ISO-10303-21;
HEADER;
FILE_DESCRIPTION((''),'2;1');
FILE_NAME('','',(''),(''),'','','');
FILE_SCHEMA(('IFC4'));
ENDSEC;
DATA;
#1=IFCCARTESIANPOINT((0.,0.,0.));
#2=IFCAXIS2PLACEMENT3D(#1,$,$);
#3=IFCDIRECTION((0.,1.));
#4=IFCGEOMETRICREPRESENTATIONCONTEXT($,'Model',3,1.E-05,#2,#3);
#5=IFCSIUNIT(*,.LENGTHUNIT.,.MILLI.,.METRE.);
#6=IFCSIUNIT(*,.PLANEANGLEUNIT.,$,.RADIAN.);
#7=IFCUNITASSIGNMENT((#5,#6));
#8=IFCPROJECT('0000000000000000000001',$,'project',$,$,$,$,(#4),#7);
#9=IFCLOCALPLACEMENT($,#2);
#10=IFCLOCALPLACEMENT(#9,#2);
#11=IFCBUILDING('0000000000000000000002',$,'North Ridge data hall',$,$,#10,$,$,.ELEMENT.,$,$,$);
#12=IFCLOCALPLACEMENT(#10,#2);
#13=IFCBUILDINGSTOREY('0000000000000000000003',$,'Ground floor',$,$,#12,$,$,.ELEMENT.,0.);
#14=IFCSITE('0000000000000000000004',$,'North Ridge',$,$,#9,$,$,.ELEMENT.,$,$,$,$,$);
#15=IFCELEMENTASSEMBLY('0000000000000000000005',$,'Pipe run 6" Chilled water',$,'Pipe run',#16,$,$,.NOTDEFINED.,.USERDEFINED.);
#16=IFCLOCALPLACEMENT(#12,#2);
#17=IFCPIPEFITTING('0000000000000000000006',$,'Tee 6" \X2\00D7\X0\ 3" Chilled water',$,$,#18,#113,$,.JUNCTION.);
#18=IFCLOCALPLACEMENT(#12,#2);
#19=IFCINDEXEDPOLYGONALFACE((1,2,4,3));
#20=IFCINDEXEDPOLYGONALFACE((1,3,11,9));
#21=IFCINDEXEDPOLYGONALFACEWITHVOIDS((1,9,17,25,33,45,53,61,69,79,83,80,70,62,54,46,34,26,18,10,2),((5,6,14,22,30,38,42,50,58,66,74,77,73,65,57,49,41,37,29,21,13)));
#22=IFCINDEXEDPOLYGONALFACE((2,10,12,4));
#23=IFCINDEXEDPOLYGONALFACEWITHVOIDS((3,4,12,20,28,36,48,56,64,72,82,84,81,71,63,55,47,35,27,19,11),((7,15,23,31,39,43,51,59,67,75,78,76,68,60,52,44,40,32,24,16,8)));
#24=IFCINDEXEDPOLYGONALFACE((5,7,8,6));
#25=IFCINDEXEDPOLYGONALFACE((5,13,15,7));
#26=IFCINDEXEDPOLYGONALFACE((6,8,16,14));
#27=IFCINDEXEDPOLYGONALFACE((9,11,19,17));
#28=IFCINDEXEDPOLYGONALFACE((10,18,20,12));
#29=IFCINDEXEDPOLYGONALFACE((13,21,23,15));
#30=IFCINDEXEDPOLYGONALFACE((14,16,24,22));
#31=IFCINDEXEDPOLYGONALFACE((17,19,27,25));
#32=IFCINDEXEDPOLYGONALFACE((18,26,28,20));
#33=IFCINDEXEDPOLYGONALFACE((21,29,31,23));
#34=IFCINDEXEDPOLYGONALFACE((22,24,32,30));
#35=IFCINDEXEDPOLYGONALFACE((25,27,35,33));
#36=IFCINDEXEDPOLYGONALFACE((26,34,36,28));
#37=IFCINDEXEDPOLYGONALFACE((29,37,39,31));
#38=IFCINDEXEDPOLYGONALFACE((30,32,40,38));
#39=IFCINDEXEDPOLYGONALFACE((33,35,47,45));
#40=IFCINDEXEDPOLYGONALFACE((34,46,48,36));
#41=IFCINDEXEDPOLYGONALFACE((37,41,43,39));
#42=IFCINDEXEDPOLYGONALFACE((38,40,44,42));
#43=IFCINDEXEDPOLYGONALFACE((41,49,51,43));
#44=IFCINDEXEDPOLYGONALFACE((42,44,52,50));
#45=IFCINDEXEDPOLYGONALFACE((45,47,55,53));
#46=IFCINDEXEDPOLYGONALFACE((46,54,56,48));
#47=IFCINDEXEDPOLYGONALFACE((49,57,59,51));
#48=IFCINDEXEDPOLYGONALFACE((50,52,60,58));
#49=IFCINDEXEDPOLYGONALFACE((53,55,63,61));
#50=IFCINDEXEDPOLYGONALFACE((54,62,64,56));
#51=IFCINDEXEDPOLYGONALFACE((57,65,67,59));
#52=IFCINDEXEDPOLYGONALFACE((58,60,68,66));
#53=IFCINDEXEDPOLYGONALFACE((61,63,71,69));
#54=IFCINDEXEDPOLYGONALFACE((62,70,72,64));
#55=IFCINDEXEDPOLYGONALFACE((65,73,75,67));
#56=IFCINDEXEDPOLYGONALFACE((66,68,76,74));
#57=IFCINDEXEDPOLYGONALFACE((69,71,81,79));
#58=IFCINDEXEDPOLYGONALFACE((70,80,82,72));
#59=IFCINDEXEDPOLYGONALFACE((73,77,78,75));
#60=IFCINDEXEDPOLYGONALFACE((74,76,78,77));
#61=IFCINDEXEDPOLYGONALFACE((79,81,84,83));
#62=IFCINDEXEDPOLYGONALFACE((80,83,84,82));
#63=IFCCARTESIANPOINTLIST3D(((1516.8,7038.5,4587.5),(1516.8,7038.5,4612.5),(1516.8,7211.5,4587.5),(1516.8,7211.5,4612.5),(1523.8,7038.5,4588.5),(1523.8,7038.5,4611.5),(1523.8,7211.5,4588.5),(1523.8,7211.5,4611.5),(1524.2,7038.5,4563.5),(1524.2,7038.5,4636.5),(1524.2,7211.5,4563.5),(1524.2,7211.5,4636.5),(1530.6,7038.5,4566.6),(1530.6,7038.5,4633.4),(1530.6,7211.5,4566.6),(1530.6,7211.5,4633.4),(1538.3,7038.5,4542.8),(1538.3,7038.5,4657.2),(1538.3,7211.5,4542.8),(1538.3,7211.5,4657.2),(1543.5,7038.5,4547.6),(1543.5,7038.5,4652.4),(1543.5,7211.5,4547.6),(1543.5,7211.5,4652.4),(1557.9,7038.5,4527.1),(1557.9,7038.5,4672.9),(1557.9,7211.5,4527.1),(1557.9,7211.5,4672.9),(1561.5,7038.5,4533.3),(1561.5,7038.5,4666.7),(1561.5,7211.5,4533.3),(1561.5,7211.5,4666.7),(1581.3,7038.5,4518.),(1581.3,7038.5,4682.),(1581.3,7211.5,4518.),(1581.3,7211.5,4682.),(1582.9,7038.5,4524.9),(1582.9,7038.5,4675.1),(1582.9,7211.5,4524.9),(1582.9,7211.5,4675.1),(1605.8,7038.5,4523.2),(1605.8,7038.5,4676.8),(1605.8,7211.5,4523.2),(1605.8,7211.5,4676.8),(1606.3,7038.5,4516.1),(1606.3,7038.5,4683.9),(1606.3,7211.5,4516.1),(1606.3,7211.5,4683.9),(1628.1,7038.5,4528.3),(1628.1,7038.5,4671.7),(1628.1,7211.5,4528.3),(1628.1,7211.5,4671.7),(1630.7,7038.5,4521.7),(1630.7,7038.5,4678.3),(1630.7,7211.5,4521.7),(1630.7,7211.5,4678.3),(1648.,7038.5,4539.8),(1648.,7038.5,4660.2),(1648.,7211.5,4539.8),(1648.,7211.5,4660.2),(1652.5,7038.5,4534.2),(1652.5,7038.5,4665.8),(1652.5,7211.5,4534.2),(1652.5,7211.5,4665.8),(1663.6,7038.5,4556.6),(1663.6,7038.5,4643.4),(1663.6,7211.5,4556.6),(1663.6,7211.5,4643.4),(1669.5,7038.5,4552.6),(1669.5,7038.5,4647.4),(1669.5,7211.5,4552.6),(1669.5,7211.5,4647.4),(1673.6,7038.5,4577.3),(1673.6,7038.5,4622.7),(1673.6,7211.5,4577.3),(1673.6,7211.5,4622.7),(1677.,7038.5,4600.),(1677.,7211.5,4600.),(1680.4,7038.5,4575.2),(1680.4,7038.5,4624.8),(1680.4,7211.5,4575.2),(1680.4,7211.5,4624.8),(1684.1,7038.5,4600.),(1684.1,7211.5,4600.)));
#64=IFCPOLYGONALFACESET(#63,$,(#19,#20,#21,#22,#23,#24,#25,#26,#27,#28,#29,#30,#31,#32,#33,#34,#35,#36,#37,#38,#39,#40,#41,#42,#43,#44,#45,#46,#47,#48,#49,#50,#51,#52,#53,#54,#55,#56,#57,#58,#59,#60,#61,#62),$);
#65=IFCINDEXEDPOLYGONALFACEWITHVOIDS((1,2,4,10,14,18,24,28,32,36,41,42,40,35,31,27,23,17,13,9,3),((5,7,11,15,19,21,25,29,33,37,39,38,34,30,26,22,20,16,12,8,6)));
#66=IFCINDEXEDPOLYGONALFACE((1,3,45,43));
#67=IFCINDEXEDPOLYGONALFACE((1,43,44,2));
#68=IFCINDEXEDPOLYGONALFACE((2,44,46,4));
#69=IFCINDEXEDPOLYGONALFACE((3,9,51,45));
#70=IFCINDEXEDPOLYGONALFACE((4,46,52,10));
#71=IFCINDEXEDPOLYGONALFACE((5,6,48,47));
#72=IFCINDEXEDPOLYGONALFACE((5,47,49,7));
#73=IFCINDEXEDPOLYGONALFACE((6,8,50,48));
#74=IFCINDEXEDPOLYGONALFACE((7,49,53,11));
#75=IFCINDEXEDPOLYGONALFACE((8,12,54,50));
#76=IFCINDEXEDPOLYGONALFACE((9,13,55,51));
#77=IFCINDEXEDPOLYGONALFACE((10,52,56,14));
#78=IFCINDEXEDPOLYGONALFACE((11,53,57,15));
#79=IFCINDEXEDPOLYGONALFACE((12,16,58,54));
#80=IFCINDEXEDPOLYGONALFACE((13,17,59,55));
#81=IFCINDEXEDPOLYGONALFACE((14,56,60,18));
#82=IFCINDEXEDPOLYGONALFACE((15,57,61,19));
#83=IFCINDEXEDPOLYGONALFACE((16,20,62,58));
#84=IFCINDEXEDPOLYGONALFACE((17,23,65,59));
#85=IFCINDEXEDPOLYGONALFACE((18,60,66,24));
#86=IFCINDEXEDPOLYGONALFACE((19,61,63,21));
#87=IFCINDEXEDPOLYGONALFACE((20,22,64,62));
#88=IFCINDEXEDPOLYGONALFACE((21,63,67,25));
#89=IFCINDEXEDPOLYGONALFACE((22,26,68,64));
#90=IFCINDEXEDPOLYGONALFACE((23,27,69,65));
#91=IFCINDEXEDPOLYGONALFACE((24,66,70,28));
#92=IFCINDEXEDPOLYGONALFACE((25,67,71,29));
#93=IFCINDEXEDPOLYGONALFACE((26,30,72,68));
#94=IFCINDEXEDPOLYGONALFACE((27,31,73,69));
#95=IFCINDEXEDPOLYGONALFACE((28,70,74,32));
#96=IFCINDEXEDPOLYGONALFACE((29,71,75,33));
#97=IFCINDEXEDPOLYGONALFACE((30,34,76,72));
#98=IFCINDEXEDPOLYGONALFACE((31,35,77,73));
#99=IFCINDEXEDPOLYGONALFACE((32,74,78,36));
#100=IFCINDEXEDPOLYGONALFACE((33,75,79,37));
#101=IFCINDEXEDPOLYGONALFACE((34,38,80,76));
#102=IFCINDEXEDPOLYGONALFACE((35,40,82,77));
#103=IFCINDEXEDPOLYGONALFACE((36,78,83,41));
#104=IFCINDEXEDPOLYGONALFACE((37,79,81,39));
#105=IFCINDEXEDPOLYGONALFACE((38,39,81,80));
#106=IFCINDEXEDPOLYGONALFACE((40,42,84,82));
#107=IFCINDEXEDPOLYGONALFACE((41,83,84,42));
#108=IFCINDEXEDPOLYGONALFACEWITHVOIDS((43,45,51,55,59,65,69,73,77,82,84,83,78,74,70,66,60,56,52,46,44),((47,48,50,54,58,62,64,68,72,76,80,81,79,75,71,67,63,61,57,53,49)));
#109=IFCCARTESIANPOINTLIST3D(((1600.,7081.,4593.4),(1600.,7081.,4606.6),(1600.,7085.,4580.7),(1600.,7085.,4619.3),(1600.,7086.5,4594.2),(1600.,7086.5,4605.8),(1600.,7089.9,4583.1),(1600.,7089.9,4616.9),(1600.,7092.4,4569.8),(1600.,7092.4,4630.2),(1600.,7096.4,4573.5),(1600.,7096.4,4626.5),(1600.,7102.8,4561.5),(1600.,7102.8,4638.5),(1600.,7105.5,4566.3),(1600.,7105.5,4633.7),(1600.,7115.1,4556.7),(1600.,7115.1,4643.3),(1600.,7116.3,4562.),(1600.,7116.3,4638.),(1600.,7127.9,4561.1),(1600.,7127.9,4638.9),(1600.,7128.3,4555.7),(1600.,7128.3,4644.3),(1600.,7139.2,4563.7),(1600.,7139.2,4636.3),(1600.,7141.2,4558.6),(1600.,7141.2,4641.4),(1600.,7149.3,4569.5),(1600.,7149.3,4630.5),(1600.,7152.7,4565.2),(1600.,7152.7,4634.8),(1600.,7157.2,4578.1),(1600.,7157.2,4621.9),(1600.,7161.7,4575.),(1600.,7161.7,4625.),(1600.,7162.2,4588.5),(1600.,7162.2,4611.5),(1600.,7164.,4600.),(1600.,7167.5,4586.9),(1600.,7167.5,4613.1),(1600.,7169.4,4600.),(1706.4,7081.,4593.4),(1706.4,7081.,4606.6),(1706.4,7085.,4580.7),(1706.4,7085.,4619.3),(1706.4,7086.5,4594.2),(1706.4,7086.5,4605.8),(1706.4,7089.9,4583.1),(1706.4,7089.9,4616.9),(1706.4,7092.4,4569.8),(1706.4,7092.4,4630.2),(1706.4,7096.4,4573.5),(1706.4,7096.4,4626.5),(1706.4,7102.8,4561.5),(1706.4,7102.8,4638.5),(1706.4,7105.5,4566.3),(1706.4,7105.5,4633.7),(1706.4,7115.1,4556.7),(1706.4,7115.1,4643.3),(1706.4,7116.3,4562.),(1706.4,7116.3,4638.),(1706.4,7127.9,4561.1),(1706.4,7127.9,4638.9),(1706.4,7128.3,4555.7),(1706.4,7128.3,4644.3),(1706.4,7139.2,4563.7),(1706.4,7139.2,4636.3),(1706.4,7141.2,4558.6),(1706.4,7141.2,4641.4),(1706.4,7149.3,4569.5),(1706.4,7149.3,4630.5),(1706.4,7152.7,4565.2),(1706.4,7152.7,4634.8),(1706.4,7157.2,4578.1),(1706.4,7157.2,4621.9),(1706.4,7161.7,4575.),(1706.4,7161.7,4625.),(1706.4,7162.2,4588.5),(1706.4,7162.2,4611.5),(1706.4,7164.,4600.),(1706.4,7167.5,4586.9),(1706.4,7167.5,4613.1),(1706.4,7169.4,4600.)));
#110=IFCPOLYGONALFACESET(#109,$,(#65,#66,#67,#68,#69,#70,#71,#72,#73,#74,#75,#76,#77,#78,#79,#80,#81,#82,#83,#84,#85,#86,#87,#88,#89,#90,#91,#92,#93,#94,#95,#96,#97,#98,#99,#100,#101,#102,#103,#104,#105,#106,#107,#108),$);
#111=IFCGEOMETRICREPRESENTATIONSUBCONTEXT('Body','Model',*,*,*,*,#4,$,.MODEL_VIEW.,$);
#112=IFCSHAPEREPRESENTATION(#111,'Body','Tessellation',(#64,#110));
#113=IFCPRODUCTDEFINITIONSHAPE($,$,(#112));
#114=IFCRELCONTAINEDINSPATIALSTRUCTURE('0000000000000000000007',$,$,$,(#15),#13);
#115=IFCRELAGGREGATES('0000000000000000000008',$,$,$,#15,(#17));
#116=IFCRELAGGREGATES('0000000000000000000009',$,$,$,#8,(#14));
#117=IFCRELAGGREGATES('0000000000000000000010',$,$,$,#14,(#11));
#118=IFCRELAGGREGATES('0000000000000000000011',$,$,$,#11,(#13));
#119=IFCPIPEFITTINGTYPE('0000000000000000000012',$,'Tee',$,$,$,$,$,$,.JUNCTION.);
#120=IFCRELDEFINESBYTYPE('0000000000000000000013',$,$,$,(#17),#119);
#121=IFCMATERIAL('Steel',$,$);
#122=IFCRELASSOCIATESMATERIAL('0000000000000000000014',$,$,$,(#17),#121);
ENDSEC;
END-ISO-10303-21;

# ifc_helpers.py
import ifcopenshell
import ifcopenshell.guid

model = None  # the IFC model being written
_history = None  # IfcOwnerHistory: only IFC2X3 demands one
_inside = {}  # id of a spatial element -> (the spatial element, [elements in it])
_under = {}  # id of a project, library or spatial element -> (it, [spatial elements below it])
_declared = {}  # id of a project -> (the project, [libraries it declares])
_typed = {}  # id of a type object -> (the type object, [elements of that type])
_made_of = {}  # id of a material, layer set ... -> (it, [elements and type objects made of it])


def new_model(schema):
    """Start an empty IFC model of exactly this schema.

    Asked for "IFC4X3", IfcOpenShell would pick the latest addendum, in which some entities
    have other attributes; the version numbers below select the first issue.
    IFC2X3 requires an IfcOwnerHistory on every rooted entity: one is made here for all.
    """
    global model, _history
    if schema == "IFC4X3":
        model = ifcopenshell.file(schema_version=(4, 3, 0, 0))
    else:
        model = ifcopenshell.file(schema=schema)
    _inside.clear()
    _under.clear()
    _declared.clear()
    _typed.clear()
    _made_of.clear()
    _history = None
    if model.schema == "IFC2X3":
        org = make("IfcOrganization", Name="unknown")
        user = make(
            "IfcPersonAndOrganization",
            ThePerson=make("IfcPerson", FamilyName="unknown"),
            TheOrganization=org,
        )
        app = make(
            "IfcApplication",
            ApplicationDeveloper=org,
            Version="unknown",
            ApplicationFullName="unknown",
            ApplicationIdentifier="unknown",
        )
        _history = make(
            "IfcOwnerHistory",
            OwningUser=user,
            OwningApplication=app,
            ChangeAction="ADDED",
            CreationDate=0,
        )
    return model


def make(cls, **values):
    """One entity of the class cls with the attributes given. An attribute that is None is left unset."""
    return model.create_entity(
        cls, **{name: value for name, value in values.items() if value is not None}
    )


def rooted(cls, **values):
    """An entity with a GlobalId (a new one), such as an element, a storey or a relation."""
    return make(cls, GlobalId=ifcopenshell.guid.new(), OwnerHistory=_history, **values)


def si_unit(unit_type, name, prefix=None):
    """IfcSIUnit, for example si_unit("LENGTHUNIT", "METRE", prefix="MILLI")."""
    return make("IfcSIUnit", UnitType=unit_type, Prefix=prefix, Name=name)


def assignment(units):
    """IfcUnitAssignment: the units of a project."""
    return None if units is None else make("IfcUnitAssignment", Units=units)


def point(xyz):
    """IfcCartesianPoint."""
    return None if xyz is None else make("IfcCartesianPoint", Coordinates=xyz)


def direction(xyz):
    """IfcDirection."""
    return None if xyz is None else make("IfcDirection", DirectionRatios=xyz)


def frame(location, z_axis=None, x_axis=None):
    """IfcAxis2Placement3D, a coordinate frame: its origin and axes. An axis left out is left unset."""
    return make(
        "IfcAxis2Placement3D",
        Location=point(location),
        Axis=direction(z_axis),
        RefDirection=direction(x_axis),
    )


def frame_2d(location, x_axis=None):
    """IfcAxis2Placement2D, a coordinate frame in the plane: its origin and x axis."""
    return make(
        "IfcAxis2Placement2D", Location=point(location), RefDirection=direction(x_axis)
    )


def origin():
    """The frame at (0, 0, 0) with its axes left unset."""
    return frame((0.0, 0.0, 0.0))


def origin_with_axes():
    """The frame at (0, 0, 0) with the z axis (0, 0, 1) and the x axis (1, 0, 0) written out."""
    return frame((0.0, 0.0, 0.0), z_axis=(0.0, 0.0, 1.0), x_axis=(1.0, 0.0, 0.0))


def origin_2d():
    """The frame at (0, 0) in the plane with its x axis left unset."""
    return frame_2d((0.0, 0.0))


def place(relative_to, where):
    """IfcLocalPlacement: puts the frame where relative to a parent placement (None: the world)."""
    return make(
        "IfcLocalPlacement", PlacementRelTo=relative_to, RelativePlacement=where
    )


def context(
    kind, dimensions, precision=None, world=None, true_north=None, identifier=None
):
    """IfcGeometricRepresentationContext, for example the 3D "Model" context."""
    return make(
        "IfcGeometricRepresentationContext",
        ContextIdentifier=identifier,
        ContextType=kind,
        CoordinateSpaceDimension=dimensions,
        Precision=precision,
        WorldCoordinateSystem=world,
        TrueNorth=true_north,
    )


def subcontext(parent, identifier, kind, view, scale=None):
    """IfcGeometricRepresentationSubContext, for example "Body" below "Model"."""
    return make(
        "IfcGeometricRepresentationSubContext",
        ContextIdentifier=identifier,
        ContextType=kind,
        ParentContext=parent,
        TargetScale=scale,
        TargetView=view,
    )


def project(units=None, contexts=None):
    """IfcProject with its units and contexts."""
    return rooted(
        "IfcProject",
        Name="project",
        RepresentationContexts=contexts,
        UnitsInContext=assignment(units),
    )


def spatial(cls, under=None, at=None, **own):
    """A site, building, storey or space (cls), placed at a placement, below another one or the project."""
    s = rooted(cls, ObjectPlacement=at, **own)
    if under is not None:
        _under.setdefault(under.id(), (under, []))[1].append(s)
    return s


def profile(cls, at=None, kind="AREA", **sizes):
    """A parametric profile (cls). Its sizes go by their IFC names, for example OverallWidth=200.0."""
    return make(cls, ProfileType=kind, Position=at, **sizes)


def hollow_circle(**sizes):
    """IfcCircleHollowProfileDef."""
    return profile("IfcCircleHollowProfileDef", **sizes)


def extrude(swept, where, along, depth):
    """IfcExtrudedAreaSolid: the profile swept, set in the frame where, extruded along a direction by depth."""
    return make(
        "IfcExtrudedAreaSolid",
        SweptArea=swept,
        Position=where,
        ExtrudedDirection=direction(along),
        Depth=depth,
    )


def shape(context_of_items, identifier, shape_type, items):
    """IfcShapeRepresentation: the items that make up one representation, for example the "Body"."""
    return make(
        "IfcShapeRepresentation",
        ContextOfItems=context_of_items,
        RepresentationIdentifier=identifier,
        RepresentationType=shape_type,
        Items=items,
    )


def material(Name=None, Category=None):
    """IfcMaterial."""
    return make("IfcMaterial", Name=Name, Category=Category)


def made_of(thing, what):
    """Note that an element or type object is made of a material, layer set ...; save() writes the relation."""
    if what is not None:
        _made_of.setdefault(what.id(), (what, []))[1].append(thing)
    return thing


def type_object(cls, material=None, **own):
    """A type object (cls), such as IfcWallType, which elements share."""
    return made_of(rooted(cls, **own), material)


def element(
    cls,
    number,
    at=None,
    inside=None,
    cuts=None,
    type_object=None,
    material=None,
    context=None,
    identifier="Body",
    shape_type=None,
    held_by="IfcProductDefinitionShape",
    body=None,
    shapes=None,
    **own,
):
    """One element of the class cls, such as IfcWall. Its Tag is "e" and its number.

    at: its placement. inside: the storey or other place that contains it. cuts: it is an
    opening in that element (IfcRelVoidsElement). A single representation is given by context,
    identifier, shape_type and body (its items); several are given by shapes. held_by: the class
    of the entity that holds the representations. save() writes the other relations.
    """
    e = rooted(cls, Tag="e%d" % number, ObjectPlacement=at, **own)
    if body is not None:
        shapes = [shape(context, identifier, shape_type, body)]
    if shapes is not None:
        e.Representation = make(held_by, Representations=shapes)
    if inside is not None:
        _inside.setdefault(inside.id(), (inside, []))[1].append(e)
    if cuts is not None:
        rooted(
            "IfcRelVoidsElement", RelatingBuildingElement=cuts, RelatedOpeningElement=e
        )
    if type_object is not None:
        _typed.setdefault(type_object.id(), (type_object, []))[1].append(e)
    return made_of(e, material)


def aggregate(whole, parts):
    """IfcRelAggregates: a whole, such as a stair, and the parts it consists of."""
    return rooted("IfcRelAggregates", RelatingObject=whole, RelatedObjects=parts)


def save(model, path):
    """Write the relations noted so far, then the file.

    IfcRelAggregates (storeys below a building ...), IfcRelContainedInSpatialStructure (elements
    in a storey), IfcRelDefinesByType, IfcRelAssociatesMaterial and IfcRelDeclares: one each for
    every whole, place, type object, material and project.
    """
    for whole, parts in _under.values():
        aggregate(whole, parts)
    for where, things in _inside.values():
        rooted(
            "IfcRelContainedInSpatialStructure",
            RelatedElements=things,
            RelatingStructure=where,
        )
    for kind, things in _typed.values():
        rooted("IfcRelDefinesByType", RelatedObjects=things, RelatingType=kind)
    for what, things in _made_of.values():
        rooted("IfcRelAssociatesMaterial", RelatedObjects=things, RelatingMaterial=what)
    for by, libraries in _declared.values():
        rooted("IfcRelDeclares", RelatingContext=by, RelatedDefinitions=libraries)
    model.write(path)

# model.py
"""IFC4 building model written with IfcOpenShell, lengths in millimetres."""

from ifc_helpers import new_model, si_unit, direction, frame, origin, origin_with_axes, origin_2d, place, context, subcontext, project, spatial, hollow_circle, extrude, material, type_object, element, aggregate, save


model = new_model("IFC4")

# Units and contexts
model_context = context("Model", 3, precision=1e-05, world=origin(), true_north=direction((0.0, 1.0)))
body_context = subcontext(model_context, "Body", "Model", "MODEL_VIEW")
ifc_project = project(units=[si_unit("LENGTHUNIT", "METRE", prefix="MILLI"), si_unit("PLANEANGLEUNIT", "RADIAN")], contexts=[model_context])

# Site, building, storey
site_placement = place(None, origin())
site = spatial("IfcSite", under=ifc_project, at=site_placement, Name="North Ridge", CompositionType="ELEMENT")
building_placement = place(site_placement, origin())
building = spatial("IfcBuilding", under=site, at=building_placement, Name="North Ridge data hall", CompositionType="ELEMENT")
storey_placement = place(building_placement, origin())
storey = spatial("IfcBuildingStorey", under=building, at=storey_placement, Name="Ground floor", CompositionType="ELEMENT", Elevation=0.0)

# Element assembly
ifc_material_1 = material(Name="Steel")
assembly_1_placement = place(storey_placement, origin_with_axes())
assembly_1 = element("IfcElementAssembly", 1, at=assembly_1_placement, inside=storey, Name="Pipe run 6\" Chilled water", ObjectType="Pipe run", AssemblyPlace="NOTDEFINED", PredefinedType="USERDEFINED")

# Pipe fitting
pipe_fitting_type_1 = type_object("IfcPipeFittingType", Name="Tee", PredefinedType="JUNCTION")
pipe_fitting_1_placement = place(storey_placement, origin_with_axes())
pipe_fitting_1 = element("IfcPipeFitting", 2, at=pipe_fitting_1_placement, type_object=pipe_fitting_type_1, material=ifc_material_1, Name="Tee 6\" × 3\" Chilled water", PredefinedType="JUNCTION", context=body_context, shape_type="SweptSolid", body=[
    extrude(hollow_circle(Radius=84.1, WallThickness=7.1, at=origin_2d()), frame((1600.0, 7211.5, 4600.0), z_axis=(0.0, -1.0, 0.0), x_axis=(1.0, 0.0, 0.0)), (0.0, 0.0, 1.0), 173.0),
    extrude(hollow_circle(Radius=44.5, WallThickness=5.5, at=origin_2d()), frame((1600.0, 7125.0, 4600.0), z_axis=(1.0, 0.0, 0.0), x_axis=(0.0, 1.0, 0.0)), (0.0, 0.0, 1.0), 106.4),
])
aggregate(assembly_1, [pipe_fitting_1])

save(model, "model.ifc")
